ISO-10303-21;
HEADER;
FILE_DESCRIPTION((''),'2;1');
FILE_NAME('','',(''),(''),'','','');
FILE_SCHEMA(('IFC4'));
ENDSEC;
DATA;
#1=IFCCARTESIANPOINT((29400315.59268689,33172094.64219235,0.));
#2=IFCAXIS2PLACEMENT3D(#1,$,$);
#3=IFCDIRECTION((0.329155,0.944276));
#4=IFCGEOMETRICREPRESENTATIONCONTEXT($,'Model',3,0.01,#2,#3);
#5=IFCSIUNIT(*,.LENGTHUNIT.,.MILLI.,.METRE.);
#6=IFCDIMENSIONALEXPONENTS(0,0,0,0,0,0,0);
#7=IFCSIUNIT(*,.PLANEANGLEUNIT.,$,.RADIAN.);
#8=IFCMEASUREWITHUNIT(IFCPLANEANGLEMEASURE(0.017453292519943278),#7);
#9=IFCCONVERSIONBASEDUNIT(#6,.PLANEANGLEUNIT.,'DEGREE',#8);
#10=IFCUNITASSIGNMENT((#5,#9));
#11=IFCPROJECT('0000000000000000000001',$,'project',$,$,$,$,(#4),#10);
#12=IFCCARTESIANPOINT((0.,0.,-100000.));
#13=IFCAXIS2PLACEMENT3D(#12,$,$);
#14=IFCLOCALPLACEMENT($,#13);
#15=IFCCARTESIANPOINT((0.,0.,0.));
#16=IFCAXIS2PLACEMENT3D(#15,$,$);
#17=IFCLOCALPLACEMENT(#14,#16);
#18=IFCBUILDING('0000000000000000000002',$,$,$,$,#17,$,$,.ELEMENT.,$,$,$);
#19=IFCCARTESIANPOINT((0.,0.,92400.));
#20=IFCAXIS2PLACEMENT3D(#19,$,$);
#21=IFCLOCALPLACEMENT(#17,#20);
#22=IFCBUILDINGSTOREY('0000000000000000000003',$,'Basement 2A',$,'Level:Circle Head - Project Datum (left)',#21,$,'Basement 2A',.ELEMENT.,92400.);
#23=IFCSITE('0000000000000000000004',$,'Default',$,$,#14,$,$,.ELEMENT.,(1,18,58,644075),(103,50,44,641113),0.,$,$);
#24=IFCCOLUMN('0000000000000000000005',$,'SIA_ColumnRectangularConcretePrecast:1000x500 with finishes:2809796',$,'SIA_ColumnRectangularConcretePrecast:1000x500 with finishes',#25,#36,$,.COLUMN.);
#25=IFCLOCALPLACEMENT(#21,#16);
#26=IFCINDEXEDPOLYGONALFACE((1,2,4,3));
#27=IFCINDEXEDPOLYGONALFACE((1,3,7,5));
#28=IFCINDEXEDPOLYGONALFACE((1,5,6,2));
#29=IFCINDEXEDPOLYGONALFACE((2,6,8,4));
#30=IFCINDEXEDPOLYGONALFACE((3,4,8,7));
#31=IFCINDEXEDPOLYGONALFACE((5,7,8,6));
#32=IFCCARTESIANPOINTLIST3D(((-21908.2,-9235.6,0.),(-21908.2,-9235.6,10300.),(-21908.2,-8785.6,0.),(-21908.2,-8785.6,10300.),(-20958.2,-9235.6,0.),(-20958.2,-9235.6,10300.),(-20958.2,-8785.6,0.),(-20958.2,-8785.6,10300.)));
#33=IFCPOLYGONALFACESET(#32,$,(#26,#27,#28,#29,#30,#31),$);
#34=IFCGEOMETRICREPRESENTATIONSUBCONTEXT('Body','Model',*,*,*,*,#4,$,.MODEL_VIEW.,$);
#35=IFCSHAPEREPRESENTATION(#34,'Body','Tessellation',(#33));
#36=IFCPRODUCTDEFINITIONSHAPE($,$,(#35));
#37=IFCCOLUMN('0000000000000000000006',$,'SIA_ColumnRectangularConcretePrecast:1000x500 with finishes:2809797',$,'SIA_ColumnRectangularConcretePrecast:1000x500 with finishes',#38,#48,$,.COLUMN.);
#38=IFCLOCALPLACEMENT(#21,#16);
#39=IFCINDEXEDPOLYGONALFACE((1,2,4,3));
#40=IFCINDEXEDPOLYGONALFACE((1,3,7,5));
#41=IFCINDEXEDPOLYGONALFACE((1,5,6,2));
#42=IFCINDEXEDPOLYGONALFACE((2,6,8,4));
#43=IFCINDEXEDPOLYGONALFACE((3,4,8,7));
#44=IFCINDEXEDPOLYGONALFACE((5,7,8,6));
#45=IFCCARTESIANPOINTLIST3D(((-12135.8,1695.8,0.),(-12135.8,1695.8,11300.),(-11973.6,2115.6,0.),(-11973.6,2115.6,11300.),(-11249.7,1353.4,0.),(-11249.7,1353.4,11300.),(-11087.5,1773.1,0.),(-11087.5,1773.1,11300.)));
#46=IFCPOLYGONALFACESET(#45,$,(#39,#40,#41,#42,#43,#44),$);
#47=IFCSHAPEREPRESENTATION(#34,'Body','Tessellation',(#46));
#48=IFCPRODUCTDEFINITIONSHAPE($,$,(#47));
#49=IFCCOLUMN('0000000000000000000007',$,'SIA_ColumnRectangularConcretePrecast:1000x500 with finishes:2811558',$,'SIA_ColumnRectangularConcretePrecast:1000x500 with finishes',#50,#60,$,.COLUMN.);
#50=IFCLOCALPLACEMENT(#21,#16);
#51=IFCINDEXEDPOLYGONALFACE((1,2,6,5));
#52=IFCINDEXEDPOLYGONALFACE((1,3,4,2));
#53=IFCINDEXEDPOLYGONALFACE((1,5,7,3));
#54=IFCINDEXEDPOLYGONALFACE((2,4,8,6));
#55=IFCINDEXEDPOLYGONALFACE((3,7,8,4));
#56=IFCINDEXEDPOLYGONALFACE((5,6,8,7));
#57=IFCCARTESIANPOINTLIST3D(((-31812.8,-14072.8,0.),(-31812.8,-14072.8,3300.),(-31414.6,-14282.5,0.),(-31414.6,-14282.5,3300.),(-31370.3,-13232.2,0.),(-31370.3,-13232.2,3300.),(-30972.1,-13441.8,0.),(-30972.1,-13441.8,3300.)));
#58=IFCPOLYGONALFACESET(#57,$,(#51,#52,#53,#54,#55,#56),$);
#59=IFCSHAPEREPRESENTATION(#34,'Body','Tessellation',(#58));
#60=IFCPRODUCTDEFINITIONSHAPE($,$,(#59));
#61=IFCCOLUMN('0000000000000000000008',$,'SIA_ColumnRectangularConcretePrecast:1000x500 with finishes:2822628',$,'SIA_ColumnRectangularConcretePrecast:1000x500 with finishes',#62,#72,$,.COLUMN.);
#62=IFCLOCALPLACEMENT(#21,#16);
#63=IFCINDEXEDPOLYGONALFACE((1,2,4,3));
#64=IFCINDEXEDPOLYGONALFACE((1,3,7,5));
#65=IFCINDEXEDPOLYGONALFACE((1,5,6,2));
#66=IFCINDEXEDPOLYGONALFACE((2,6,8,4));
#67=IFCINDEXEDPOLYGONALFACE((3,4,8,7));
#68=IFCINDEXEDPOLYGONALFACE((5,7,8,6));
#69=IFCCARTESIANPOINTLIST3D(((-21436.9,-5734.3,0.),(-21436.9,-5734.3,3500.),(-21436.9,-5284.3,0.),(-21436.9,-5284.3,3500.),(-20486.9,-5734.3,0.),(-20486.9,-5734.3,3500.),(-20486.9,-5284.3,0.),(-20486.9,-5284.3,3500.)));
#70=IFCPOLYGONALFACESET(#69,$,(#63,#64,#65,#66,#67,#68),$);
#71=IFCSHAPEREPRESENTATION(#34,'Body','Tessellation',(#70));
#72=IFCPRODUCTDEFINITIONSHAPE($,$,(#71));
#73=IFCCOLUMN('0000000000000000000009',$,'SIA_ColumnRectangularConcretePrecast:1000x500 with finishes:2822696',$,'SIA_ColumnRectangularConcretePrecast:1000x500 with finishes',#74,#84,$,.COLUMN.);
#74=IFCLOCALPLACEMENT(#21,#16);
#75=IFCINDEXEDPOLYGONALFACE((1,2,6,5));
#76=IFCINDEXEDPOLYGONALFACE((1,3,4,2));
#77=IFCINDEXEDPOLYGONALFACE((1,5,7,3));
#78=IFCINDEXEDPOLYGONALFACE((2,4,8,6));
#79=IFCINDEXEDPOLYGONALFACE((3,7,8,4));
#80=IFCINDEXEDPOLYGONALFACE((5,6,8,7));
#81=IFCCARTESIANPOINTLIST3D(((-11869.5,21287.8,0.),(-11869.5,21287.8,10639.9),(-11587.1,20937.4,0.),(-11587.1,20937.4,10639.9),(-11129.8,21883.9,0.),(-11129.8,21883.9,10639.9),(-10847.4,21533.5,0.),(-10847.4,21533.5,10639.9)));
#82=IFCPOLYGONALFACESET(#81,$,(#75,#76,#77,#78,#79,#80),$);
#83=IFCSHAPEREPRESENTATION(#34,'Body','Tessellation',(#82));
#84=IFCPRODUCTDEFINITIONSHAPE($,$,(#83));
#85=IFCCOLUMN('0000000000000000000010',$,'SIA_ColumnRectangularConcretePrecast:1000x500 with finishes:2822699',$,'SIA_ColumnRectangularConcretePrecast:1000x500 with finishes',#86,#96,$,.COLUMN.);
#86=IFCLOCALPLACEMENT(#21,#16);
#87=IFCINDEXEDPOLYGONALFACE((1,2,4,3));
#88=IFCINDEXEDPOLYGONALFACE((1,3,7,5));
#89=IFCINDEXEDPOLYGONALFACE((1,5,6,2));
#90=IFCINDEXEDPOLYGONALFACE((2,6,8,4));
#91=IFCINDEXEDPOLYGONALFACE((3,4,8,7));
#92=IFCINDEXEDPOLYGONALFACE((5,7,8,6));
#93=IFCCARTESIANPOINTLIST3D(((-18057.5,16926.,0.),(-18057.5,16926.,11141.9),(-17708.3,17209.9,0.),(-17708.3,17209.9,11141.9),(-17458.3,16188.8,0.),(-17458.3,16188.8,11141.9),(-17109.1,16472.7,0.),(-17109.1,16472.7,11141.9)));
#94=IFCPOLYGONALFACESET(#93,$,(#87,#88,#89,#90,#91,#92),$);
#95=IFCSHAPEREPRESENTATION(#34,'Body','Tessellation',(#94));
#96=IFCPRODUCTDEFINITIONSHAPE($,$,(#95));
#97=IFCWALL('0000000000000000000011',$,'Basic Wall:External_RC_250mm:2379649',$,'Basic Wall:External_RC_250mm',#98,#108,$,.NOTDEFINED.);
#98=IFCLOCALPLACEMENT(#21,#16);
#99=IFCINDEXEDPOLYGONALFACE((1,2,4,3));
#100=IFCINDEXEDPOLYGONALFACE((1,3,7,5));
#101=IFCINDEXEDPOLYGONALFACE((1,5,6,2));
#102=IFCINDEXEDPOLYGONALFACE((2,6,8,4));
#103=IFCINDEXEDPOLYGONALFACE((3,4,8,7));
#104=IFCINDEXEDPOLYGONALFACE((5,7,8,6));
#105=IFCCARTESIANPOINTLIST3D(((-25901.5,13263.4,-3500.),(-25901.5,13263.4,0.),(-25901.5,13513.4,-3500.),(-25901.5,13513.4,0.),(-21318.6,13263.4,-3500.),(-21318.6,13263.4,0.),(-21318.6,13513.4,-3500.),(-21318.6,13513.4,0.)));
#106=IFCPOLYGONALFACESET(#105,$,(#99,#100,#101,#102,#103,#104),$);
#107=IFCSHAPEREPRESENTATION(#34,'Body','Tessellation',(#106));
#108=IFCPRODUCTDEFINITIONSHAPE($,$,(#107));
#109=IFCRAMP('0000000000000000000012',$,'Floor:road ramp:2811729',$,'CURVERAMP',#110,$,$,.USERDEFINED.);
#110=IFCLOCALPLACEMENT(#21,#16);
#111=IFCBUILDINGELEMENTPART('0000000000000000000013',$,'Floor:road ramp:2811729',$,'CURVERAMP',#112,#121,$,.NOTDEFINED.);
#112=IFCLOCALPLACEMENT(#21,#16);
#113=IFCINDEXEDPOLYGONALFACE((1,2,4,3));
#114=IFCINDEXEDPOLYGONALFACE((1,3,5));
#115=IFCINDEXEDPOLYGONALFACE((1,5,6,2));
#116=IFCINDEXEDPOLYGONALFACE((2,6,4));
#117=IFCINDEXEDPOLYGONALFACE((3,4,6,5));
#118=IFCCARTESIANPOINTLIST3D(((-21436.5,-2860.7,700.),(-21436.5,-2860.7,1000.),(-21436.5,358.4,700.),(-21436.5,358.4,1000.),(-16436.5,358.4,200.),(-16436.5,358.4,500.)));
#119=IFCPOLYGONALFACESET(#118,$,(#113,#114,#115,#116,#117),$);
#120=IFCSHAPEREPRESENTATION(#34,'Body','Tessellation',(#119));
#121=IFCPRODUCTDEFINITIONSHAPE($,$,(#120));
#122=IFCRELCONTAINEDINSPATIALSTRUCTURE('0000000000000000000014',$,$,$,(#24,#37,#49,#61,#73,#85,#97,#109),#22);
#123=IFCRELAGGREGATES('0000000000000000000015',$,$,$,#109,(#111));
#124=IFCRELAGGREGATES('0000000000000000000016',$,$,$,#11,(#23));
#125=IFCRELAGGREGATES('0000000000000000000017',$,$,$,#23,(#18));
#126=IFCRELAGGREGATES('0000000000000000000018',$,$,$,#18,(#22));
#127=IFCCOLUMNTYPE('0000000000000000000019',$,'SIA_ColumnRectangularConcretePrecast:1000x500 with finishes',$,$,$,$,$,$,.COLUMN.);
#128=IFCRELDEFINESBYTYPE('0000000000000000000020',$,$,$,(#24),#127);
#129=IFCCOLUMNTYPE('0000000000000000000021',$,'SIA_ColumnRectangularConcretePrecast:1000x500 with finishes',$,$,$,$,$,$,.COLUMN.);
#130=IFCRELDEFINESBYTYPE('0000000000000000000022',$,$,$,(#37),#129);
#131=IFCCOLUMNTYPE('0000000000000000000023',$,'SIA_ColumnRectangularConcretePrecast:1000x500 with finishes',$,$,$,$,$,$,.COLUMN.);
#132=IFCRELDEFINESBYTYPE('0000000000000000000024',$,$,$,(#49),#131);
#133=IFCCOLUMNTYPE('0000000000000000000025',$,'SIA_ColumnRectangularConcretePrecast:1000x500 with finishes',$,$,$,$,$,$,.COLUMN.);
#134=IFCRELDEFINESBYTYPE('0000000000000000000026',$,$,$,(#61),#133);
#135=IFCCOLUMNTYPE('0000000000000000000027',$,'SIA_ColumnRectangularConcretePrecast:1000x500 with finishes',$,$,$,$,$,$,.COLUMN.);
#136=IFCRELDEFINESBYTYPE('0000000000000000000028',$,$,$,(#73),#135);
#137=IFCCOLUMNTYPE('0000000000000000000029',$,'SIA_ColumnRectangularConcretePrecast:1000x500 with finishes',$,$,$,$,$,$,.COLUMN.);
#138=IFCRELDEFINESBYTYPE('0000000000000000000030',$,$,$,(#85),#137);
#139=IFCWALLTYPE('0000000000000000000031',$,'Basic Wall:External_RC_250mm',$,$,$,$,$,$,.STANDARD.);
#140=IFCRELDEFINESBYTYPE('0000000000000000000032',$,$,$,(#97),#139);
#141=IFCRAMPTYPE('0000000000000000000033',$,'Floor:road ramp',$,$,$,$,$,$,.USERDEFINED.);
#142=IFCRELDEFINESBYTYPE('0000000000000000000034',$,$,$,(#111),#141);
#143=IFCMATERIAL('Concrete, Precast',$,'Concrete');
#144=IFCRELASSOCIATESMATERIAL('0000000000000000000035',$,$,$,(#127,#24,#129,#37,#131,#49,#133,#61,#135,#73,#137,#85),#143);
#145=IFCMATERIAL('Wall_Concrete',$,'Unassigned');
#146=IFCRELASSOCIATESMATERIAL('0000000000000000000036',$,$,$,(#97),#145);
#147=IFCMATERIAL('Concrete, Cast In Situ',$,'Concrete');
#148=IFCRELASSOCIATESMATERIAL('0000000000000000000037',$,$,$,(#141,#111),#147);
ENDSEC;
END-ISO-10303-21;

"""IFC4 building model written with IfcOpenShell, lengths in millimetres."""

from ifc_helpers import new_model, entity, si_unit, converted_unit, direction, frame, origin, place, context, subcontext, project, spatial, indexed_curve, outline, extrude, source, transform, mapped, material, type_object, type_shapes, element, aggregate, save


model = new_model("IFC4")

# Units and contexts
model_context = context("Model", 3, precision=0.01, world=frame((29400315.59268689, 33172094.64219235, 0.0)), true_north=direction((0.329155, 0.944276)))
body_context = subcontext(model_context, "Body", "Model", "MODEL_VIEW")
ifc_project = project(units=[si_unit("LENGTHUNIT", "METRE", prefix="MILLI"), converted_unit("PLANEANGLEUNIT", "DEGREE", entity("IfcPlaneAngleMeasure", 0.017453292519943278), si_unit("PLANEANGLEUNIT", "RADIAN"), dimensions=[0, 0, 0, 0, 0, 0, 0])], contexts=[model_context])

# Site, building, storey
site_placement = place(None, frame((0.0, 0.0, -100000.0)))
site = spatial("IfcSite", under=ifc_project, at=site_placement, Name="Default", CompositionType="ELEMENT", RefLatitude=(1, 18, 58, 644075), RefLongitude=(103, 50, 44, 641113), RefElevation=0.0)
building_placement = place(site_placement, origin())
building = spatial("IfcBuilding", under=site, at=building_placement, CompositionType="ELEMENT")
storey_placement = place(building_placement, frame((0.0, 0.0, 92400.0)))
storey = spatial("IfcBuildingStorey", under=building, at=storey_placement, Name="Basement 2A", ObjectType="Level:Circle Head - Project Datum (left)", LongName="Basement 2A", CompositionType="ELEMENT", Elevation=92400.0)

# Columns
ifc_material_1 = material(Name="Concrete, Precast", Category="Concrete")
column_type_1 = type_object("IfcColumnType", Name="SIA_ColumnRectangularConcretePrecast:1000x500 with finishes", PredefinedType="COLUMN", material=ifc_material_1)
shared_shape_1 = source(origin(), body_context, "Body", "SweptSolid", [
    extrude(outline(indexed_curve([(-225.0, -475.0), (225.0, -475.0), (225.0, 475.0), (-225.0, 475.0), (-225.0, -475.0)], self_intersect=False)), frame((-21433.2, -9010.6, 92400.0), z_axis=(0.0, 0.0, 1.0), x_axis=(0.0, 1.0, 0.0)), (0.0, 0.0, 1.0), 10300.0),
])
type_shapes(column_type_1, [shared_shape_1])
column_1_placement = place(storey_placement, frame((0.0, 0.0, -92400.0)))
element("IfcColumn", 1, at=column_1_placement, inside=storey, type_object=column_type_1, material=ifc_material_1, Name="SIA_ColumnRectangularConcretePrecast:1000x500 with finishes:2809796", ObjectType="SIA_ColumnRectangularConcretePrecast:1000x500 with finishes", PredefinedType="COLUMN", context=body_context, shape_type="MappedRepresentation", body=[
    mapped(shared_shape_1, transform((0.0, 0.0, 0.0), scale=1.0)),
])
column_type_2 = type_object("IfcColumnType", Name="SIA_ColumnRectangularConcretePrecast:1000x500 with finishes", PredefinedType="COLUMN", material=ifc_material_1)
shared_shape_2 = source(origin(), body_context, "Body", "SweptSolid", [
    extrude(outline(indexed_curve([(-225.0, -475.0), (225.0, -475.0), (225.0, 475.0), (-225.0, 475.0), (-225.0, -475.0)], self_intersect=False)), frame((-11611.7, 1734.5, 92400.0), z_axis=(0.0, 0.0, 1.0), x_axis=(-0.360492, -0.932762, 0.0)), (0.0, 0.0, 1.0), 11300.0),
])
type_shapes(column_type_2, [shared_shape_2])
column_2_placement = place(storey_placement, frame((0.0, 0.0, -92400.0)))
element("IfcColumn", 2, at=column_2_placement, inside=storey, type_object=column_type_2, material=ifc_material_1, Name="SIA_ColumnRectangularConcretePrecast:1000x500 with finishes:2809797", ObjectType="SIA_ColumnRectangularConcretePrecast:1000x500 with finishes", PredefinedType="COLUMN", context=body_context, shape_type="MappedRepresentation", body=[
    mapped(shared_shape_2, transform((0.0, 0.0, 0.0), scale=1.0)),
])
column_type_3 = type_object("IfcColumnType", Name="SIA_ColumnRectangularConcretePrecast:1000x500 with finishes", PredefinedType="COLUMN", material=ifc_material_1)
shared_shape_3 = source(origin(), body_context, "Body", "SweptSolid", [
    extrude(outline(indexed_curve([(-225.0, -475.0), (225.0, -475.0), (225.0, 475.0), (-225.0, 475.0), (-225.0, -475.0)], self_intersect=False)), frame((0.0, 0.0, 92400.0), z_axis=(0.0, 0.0, 1.0), x_axis=(-1.0, 0.0, 0.0)), (0.0, 0.0, 1.0), 3300.0),
])
type_shapes(column_type_3, [shared_shape_3])
column_3_placement = place(storey_placement, frame((-31392.5, -13757.3, -92400.0), z_axis=(0.0, 0.0, 1.0), x_axis=(0.884888, -0.465805, 0.0)))
element("IfcColumn", 3, at=column_3_placement, inside=storey, type_object=column_type_3, material=ifc_material_1, Name="SIA_ColumnRectangularConcretePrecast:1000x500 with finishes:2811558", ObjectType="SIA_ColumnRectangularConcretePrecast:1000x500 with finishes", PredefinedType="COLUMN", context=body_context, shape_type="MappedRepresentation", body=[
    mapped(shared_shape_3, transform((0.0, 0.0, 0.0), scale=1.0)),
])
column_type_4 = type_object("IfcColumnType", Name="SIA_ColumnRectangularConcretePrecast:1000x500 with finishes", PredefinedType="COLUMN", material=ifc_material_1)
shared_shape_4 = source(origin(), body_context, "Body", "SweptSolid", [
    extrude(outline(indexed_curve([(-225.0, -475.0), (225.0, -475.0), (225.0, 475.0), (-225.0, 475.0), (-225.0, -475.0)], self_intersect=False)), frame((-20961.9, -5509.3, 92400.0), z_axis=(0.0, 0.0, 1.0), x_axis=(0.0, 1.0, 0.0)), (0.0, 0.0, 1.0), 3500.0),
])
type_shapes(column_type_4, [shared_shape_4])
column_4_placement = place(storey_placement, frame((0.0, 0.0, -92400.0)))
element("IfcColumn", 4, at=column_4_placement, inside=storey, type_object=column_type_4, material=ifc_material_1, Name="SIA_ColumnRectangularConcretePrecast:1000x500 with finishes:2822628", ObjectType="SIA_ColumnRectangularConcretePrecast:1000x500 with finishes", PredefinedType="COLUMN", context=body_context, shape_type="MappedRepresentation", body=[
    mapped(shared_shape_4, transform((0.0, 0.0, 0.0), scale=1.0)),
])
column_type_5 = type_object("IfcColumnType", Name="SIA_ColumnRectangularConcretePrecast:1000x500 with finishes", PredefinedType="COLUMN", material=ifc_material_1)
shared_shape_5 = source(origin(), body_context, "Body", "SweptSolid", [
    extrude(outline(indexed_curve([(-225.0, -475.0), (225.0, -475.0), (225.0, 475.0), (-225.0, 475.0), (-225.0, -475.0)], self_intersect=False)), frame((-11358.4, 21410.7, 92400.0), z_axis=(0.0, 0.0, 1.0), x_axis=(-0.627489, 0.778625, 0.0)), (0.0, 0.0, 1.0), 10639.9),
])
type_shapes(column_type_5, [shared_shape_5])
column_5_placement = place(storey_placement, frame((0.0, 0.0, -92400.0)))
element("IfcColumn", 5, at=column_5_placement, inside=storey, type_object=column_type_5, material=ifc_material_1, Name="SIA_ColumnRectangularConcretePrecast:1000x500 with finishes:2822696", ObjectType="SIA_ColumnRectangularConcretePrecast:1000x500 with finishes", PredefinedType="COLUMN", context=body_context, shape_type="MappedRepresentation", body=[
    mapped(shared_shape_5, transform((0.0, 0.0, 0.0), scale=1.0)),
])
column_type_6 = type_object("IfcColumnType", Name="SIA_ColumnRectangularConcretePrecast:1000x500 with finishes", PredefinedType="COLUMN", material=ifc_material_1)
shared_shape_6 = source(origin(), body_context, "Body", "SweptSolid", [
    extrude(outline(indexed_curve([(-225.0, -475.0), (225.0, -475.0), (225.0, 475.0), (-225.0, 475.0), (-225.0, -475.0)], self_intersect=False)), frame((-17583.3, 16699.4, 92400.0), z_axis=(0.0, 0.0, 1.0), x_axis=(0.775999, 0.630734, 0.0)), (0.0, 0.0, 1.0), 11141.9),
])
type_shapes(column_type_6, [shared_shape_6])
column_6_placement = place(storey_placement, frame((0.0, 0.0, -92400.0)))
element("IfcColumn", 6, at=column_6_placement, inside=storey, type_object=column_type_6, material=ifc_material_1, Name="SIA_ColumnRectangularConcretePrecast:1000x500 with finishes:2822699", ObjectType="SIA_ColumnRectangularConcretePrecast:1000x500 with finishes", PredefinedType="COLUMN", context=body_context, shape_type="MappedRepresentation", body=[
    mapped(shared_shape_6, transform((0.0, 0.0, 0.0), scale=1.0)),
])

# Shared definitions
ifc_material_2 = material(Name="Concrete, Cast In Situ", Category="Concrete")

# Wall
ifc_material_3 = material(Name="Wall_Concrete", Category="Unassigned")
wall_type = type_object("IfcWallType", Name="Basic Wall:External_RC_250mm", PredefinedType="STANDARD")
wall_placement = place(storey_placement, frame((-25901.5, 13388.4, -3500.0)))
element("IfcWall", 7, at=wall_placement, inside=storey, type_object=wall_type, material=ifc_material_3, Name="Basic Wall:External_RC_250mm:2379649", ObjectType="Basic Wall:External_RC_250mm", PredefinedType="NOTDEFINED", context=body_context, shape_type="SweptSolid", body=[
    extrude(outline(indexed_curve([(4582.9, 125.0), (0.0, 125.0), (0.0, -125.0), (4582.9, -125.0), (4582.9, 125.0)], self_intersect=False)), origin(), (0.0, 0.0, 1.0), 3500.0),
])

# Ramp, building element part
ramp_placement = place(storey_placement, frame((-33162.5, -21119.8, -300.0)))
ramp = element("IfcRamp", 8, at=ramp_placement, inside=storey, Name="Floor:road ramp:2811729", ObjectType="CURVERAMP", PredefinedType="USERDEFINED")
ramp_type = type_object("IfcRampType", Name="Floor:road ramp", PredefinedType="USERDEFINED", material=ifc_material_2)
building_element_part_placement = place(ramp_placement, origin())
building_element_part = element("IfcBuildingElementPart", 9, at=building_element_part_placement, type_object=ramp_type, material=ifc_material_2, Name="Floor:road ramp:2811729", ObjectType="CURVERAMP", PredefinedType="NOTDEFINED", context=body_context, shape_type="SweptSolid", body=[
    extrude(outline(indexed_curve([(2512.5, 1609.6), (-2512.5, 1609.6), (-2512.5, -1609.6), (2512.5, 1609.6)], self_intersect=False)), frame((14226.0, 19868.7, 1050.0), z_axis=(0.099504, 0.0, 0.995037), x_axis=(0.995037, 0.0, -0.099504)), (0.099504, 0.0, -0.995037), 300.0),
])
aggregate(ramp, [building_element_part])

save(model, "model.ifc")
